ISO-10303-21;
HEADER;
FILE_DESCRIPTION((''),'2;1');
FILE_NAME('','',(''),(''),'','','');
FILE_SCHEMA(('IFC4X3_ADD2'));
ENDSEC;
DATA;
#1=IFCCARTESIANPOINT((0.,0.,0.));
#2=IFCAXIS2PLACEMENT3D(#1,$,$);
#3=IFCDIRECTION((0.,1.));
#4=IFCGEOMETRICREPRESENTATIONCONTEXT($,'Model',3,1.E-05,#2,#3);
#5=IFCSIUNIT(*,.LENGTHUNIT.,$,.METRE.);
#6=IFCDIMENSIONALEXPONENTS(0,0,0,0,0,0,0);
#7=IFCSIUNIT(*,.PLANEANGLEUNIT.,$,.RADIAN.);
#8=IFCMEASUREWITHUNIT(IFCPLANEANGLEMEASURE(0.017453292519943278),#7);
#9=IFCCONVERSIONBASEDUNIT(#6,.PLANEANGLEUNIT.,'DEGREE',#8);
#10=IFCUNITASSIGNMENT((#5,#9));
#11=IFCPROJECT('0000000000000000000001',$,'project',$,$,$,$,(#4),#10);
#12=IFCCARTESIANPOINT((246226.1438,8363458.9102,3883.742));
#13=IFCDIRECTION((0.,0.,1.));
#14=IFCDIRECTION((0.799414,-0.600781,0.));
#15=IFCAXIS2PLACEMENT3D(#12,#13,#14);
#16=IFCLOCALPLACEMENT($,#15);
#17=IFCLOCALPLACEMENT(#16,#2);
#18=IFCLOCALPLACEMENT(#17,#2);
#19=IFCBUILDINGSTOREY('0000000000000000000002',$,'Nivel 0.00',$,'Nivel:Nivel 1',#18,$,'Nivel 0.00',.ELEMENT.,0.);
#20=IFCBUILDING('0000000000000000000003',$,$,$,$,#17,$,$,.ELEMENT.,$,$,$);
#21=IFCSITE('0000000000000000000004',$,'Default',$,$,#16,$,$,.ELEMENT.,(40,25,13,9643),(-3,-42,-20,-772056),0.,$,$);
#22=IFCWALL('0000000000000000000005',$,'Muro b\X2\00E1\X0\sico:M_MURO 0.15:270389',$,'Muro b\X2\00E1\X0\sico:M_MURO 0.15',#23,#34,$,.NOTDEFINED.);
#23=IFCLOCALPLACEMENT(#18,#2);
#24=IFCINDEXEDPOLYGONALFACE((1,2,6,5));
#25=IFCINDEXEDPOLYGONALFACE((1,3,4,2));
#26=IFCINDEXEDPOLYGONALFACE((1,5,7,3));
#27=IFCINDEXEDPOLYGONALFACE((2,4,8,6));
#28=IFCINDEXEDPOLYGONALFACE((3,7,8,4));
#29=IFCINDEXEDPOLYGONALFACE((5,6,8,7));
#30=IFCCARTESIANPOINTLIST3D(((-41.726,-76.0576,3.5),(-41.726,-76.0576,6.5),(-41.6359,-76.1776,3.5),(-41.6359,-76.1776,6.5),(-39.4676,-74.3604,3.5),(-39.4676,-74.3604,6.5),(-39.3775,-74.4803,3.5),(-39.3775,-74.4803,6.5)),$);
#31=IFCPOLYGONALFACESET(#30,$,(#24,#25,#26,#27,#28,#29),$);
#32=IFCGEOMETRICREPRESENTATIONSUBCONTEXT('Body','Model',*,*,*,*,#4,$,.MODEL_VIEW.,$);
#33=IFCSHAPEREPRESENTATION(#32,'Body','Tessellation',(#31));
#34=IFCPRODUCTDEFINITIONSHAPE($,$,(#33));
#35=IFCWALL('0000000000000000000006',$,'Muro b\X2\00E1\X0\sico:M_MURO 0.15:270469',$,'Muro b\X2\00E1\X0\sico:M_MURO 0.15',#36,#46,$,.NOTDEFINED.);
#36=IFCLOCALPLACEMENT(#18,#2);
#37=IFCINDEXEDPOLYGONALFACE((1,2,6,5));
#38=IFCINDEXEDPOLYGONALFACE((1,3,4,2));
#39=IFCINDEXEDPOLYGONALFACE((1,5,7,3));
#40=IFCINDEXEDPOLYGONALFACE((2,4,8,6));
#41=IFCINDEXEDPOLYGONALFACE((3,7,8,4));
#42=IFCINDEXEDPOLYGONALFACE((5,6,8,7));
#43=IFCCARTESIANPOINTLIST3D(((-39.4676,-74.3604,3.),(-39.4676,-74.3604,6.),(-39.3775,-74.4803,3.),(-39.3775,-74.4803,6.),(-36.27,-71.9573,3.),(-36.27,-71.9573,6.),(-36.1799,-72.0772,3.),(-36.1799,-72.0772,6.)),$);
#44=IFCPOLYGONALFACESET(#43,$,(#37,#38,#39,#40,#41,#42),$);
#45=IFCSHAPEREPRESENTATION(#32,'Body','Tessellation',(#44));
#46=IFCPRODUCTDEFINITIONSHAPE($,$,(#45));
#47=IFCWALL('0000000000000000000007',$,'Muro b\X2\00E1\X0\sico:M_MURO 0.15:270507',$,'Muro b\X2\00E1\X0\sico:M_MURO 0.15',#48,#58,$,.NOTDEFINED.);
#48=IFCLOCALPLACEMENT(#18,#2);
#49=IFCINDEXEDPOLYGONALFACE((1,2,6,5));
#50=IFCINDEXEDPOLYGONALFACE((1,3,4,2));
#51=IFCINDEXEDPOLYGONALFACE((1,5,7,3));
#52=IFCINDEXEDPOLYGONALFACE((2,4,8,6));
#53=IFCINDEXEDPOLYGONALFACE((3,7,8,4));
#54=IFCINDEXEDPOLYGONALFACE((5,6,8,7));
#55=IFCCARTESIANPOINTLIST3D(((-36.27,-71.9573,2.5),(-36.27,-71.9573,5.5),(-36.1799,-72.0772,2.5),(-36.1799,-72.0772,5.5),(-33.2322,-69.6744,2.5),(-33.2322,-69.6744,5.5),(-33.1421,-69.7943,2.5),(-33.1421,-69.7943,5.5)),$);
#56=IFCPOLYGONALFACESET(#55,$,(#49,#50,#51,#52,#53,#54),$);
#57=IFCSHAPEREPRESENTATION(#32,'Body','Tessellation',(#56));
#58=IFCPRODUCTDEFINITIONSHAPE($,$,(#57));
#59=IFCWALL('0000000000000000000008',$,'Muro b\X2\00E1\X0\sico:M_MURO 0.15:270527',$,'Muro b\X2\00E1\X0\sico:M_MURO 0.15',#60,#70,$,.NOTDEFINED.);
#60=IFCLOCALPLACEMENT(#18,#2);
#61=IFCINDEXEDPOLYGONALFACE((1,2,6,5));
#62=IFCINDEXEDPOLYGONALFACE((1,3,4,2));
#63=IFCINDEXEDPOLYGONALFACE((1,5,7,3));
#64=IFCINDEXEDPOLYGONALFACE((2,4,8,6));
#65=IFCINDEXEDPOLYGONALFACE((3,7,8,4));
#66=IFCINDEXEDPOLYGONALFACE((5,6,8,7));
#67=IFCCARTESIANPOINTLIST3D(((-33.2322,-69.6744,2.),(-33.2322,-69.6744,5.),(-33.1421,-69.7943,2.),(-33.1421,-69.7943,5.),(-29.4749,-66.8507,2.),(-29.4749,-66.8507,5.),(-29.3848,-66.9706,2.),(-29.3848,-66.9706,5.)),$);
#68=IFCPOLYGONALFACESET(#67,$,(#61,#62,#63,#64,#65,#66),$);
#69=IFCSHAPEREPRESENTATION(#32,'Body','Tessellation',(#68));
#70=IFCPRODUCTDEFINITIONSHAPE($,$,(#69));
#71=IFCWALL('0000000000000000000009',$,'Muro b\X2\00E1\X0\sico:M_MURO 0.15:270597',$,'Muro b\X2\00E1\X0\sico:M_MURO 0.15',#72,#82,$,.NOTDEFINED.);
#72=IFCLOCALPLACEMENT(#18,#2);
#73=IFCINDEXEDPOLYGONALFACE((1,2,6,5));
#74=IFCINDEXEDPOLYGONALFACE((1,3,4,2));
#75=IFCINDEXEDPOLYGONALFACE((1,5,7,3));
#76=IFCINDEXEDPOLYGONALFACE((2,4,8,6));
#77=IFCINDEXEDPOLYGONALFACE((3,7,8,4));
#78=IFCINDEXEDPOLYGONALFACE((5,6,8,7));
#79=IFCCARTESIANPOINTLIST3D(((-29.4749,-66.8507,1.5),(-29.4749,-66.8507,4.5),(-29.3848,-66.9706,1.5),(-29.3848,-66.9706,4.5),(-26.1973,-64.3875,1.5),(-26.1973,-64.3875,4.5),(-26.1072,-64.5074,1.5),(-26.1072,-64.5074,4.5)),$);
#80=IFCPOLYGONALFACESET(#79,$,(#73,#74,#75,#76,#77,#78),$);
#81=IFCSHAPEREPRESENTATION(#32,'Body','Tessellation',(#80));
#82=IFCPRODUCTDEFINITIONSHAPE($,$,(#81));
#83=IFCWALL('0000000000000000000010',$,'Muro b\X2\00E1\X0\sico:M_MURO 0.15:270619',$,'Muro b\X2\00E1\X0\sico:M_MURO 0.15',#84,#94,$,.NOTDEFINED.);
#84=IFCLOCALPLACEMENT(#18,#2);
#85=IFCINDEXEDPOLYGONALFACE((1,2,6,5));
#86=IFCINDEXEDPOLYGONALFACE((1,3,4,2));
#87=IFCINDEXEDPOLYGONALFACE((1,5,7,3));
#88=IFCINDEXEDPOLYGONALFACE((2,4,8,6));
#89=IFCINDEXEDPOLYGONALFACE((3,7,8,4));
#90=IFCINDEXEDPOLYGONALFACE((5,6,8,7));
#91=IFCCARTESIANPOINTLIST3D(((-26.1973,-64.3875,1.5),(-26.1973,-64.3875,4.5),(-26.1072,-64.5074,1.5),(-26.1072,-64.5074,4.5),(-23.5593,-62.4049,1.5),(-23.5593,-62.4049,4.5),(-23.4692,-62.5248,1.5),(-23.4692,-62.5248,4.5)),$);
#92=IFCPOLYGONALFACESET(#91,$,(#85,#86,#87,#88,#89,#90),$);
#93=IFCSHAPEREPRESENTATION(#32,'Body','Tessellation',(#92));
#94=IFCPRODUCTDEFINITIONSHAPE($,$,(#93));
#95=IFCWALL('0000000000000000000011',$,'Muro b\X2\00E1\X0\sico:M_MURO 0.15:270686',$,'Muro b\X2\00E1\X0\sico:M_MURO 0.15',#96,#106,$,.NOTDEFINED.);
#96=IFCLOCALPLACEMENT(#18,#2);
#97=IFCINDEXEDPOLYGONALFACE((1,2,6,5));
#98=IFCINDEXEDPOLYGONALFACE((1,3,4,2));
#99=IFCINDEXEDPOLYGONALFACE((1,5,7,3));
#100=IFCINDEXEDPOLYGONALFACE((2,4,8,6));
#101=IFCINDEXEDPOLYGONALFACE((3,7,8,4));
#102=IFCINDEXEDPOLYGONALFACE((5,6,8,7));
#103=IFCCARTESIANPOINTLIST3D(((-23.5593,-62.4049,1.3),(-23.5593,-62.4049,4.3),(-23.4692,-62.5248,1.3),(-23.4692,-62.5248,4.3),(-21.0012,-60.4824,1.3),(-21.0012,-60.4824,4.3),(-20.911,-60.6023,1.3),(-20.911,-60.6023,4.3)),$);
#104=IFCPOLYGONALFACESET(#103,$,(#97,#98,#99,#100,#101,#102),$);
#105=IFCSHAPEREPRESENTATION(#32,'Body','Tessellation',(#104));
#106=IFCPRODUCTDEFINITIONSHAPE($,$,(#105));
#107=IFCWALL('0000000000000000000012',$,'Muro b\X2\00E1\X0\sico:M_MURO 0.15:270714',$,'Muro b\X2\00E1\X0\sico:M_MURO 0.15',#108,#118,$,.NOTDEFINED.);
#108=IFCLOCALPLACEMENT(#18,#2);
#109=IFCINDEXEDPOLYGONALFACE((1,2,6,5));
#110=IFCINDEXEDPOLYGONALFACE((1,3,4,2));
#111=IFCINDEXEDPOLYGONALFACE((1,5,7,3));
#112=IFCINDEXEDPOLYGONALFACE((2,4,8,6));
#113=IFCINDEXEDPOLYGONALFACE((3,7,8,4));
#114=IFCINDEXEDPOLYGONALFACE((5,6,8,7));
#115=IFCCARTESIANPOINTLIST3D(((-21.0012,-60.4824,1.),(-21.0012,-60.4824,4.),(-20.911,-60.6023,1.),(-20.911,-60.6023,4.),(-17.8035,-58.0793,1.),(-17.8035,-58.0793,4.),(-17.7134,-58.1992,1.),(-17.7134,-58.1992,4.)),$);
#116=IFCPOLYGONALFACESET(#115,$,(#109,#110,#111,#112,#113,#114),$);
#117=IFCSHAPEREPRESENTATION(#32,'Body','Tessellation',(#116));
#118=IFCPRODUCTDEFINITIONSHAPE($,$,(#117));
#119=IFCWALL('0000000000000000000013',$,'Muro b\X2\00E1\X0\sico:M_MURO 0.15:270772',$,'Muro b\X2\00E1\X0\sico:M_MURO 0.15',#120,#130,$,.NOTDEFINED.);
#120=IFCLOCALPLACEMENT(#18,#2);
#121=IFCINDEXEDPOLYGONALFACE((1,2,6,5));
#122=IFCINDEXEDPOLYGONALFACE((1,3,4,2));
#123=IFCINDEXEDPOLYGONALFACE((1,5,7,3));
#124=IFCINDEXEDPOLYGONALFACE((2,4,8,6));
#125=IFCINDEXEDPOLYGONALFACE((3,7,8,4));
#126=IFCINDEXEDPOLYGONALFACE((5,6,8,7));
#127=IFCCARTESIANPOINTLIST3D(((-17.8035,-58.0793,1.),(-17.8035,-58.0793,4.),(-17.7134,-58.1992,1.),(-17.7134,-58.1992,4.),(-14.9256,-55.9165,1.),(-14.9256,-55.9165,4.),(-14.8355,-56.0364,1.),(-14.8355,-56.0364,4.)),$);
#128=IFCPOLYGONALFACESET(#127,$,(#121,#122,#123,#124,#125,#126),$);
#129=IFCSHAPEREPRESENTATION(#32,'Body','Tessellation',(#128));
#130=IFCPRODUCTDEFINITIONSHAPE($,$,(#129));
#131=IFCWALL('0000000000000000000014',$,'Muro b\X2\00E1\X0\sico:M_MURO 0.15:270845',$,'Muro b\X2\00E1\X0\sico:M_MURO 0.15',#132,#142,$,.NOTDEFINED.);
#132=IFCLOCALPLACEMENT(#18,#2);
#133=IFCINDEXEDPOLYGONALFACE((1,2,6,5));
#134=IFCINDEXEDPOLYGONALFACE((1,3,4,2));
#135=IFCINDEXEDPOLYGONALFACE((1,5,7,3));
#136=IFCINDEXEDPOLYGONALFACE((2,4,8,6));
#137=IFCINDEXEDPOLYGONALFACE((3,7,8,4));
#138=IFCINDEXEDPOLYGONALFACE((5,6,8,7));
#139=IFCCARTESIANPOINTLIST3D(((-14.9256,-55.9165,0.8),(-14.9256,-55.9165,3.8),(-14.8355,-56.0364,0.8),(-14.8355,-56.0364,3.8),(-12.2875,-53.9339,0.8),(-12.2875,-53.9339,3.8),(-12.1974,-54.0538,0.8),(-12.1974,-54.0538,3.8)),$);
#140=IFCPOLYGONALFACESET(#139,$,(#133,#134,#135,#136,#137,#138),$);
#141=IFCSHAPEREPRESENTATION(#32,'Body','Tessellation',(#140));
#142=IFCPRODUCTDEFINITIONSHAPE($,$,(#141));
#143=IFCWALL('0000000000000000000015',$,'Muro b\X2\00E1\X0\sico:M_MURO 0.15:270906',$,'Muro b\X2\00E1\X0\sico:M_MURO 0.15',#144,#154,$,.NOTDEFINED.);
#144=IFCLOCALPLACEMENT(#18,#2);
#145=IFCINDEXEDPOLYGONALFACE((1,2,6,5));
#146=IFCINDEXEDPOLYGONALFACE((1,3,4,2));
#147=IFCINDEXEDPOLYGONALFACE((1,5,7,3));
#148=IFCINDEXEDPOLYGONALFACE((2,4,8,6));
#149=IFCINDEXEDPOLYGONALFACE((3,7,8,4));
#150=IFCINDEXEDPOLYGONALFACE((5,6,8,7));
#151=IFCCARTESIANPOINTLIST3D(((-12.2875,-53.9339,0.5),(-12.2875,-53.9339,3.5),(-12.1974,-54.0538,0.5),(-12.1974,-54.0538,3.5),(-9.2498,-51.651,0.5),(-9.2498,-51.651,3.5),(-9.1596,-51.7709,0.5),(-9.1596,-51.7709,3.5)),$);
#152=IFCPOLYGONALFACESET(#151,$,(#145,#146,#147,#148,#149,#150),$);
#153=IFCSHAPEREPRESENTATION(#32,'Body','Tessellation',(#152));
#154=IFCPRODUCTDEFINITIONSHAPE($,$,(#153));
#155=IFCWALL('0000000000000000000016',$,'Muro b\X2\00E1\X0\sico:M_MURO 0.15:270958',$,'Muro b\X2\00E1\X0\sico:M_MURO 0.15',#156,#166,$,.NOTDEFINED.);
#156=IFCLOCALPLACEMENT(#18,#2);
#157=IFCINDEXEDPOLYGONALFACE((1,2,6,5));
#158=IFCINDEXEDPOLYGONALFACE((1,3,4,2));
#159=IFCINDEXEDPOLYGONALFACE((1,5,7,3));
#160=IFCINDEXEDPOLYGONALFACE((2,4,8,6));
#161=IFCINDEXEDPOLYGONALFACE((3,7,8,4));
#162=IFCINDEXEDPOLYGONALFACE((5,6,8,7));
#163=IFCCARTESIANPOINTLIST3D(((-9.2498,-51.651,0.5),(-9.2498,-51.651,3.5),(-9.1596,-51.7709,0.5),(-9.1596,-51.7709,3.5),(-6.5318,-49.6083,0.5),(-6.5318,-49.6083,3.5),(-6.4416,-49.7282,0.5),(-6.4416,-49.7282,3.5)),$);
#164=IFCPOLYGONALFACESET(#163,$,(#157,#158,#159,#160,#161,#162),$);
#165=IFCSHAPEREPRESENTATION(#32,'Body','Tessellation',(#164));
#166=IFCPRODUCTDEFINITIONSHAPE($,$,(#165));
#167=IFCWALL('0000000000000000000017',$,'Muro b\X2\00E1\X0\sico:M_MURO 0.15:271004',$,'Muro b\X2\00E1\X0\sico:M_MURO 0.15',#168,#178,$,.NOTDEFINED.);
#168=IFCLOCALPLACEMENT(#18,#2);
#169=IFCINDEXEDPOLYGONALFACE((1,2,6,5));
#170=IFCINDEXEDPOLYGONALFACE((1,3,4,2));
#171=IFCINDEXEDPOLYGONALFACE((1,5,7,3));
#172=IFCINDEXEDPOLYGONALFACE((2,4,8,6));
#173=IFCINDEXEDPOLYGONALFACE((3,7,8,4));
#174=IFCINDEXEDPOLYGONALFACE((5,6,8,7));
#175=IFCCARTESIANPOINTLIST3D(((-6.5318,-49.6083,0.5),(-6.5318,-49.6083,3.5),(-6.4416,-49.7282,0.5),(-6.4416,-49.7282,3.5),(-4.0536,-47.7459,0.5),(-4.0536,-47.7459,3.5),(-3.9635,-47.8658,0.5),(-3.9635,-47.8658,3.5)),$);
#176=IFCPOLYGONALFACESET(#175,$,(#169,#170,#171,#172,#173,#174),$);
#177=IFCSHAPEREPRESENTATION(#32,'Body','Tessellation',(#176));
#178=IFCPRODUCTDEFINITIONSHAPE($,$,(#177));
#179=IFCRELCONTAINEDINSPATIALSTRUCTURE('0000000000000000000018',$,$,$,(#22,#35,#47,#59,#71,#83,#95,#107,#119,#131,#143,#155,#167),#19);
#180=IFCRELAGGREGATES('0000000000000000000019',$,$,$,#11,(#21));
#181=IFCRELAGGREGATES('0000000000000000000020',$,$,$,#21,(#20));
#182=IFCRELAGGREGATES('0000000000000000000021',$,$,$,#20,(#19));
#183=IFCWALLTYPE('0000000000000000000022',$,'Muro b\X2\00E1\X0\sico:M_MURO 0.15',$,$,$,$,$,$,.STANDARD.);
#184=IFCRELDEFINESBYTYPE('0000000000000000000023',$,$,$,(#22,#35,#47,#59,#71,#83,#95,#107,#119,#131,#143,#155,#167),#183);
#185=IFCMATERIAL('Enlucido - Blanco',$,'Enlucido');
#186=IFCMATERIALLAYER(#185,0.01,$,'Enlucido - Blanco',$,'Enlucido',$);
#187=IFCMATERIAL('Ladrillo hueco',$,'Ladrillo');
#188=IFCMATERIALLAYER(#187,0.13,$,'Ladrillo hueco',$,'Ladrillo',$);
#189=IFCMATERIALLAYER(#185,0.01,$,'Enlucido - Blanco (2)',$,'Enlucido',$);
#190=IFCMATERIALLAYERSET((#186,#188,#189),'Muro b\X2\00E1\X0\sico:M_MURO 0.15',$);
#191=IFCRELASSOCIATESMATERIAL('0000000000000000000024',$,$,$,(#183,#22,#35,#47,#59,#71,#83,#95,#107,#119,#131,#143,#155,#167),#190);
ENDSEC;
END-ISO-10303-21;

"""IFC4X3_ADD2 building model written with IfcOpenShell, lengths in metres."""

from ifc_helpers import new_model, entity, si_unit, converted_unit, direction, frame, frame_2d, origin, place, context, subcontext, project, spatial, rectangle, extrude, material, layer, layer_set, type_object, element, save


model = new_model("IFC4X3_ADD2")

# Units and contexts
model_context = context("Model", 3, precision=1e-05, world=origin(), true_north=direction((0.0, 1.0)))
body_context = subcontext(model_context, "Body", "Model", "MODEL_VIEW")
ifc_project = project(units=[si_unit("LENGTHUNIT", "METRE"), converted_unit("PLANEANGLEUNIT", "DEGREE", entity("IfcPlaneAngleMeasure", 0.017453292519943278), si_unit("PLANEANGLEUNIT", "RADIAN"), dimensions=[0, 0, 0, 0, 0, 0, 0])], contexts=[model_context])

# Site, building, storey
site_placement = place(None, frame((246226.1438, 8363458.9102, 3883.742), z_axis=(0.0, 0.0, 1.0), x_axis=(0.799414, -0.600781, 0.0)))
site = spatial("IfcSite", under=ifc_project, at=site_placement, Name="Default", CompositionType="ELEMENT", RefLatitude=(40, 25, 13, 9643), RefLongitude=(-3, -42, -20, -772056), RefElevation=0.0)
building_placement = place(site_placement, origin())
building = spatial("IfcBuilding", under=site, at=building_placement, CompositionType="ELEMENT")
storey_placement = place(building_placement, origin())
storey = spatial("IfcBuildingStorey", under=building, at=storey_placement, Name="Nivel 0.00", ObjectType="Nivel:Nivel 1", LongName="Nivel 0.00", CompositionType="ELEMENT", Elevation=0.0)

# Walls
ifc_material_1 = material(Name="Enlucido - Blanco", Category="Enlucido")
ifc_layer_1 = layer(ifc_material_1, 0.01, Name="Enlucido - Blanco", Category="Enlucido")
ifc_material_2 = material(Name="Ladrillo hueco", Category="Ladrillo")
ifc_layer_2 = layer(ifc_material_2, 0.13, Name="Ladrillo hueco", Category="Ladrillo")
ifc_layer_3 = layer(ifc_material_1, 0.01, Name="Enlucido - Blanco (2)", Category="Enlucido")
ifc_layer_set_1 = layer_set([ifc_layer_1, ifc_layer_2, ifc_layer_3], Name="Muro básico:M_MURO 0.15")
wall_type = type_object("IfcWallType", Name="Muro básico:M_MURO 0.15", PredefinedType="STANDARD", material=ifc_layer_set_1)
wall_1_placement = place(storey_placement, frame((-39.4226, -74.4204, 3.5), z_axis=(0.0, 0.0, 1.0), x_axis=(-0.799414, -0.60078, 0.0)))
element("IfcWall", 1, at=wall_1_placement, inside=storey, type_object=wall_type, material=ifc_layer_set_1, Name="Muro básico:M_MURO 0.15:270389", ObjectType="Muro básico:M_MURO 0.15", PredefinedType="NOTDEFINED", context=body_context, shape_type="SweptSolid", body=[
    extrude(rectangle(XDim=2.825, YDim=0.15, at=frame_2d((1.4125, 0.0), x_axis=(-1.0, 0.0))), origin(), (0.0, 0.0, 1.0), 3.0),
])
wall_2_placement = place(storey_placement, frame((-36.2249, -72.0173, 3.0), z_axis=(0.0, 0.0, 1.0), x_axis=(-0.799414, -0.60078, 0.0)))
element("IfcWall", 2, at=wall_2_placement, inside=storey, type_object=wall_type, material=ifc_layer_set_1, Name="Muro básico:M_MURO 0.15:270469", ObjectType="Muro básico:M_MURO 0.15", PredefinedType="NOTDEFINED", context=body_context, shape_type="SweptSolid", body=[
    extrude(rectangle(XDim=4.0, YDim=0.15, at=frame_2d((2.0, 0.0), x_axis=(-1.0, 0.0))), origin(), (0.0, 0.0, 1.0), 3.0),
])
wall_3_placement = place(storey_placement, frame((-33.1871, -69.7343, 2.5), z_axis=(0.0, 0.0, 1.0), x_axis=(-0.799414, -0.60078, 0.0)))
element("IfcWall", 3, at=wall_3_placement, inside=storey, type_object=wall_type, material=ifc_layer_set_1, Name="Muro básico:M_MURO 0.15:270507", ObjectType="Muro básico:M_MURO 0.15", PredefinedType="NOTDEFINED", context=body_context, shape_type="SweptSolid", body=[
    extrude(rectangle(XDim=3.8, YDim=0.15, at=frame_2d((1.9, 0.0), x_axis=(-1.0, 0.0))), origin(), (0.0, 0.0, 1.0), 3.0),
])
wall_4_placement = place(storey_placement, frame((-29.4299, -66.9106, 2.0), z_axis=(0.0, 0.0, 1.0), x_axis=(-0.799414, -0.60078, 0.0)))
element("IfcWall", 4, at=wall_4_placement, inside=storey, type_object=wall_type, material=ifc_layer_set_1, Name="Muro básico:M_MURO 0.15:270527", ObjectType="Muro básico:M_MURO 0.15", PredefinedType="NOTDEFINED", context=body_context, shape_type="SweptSolid", body=[
    extrude(rectangle(XDim=4.7, YDim=0.15, at=frame_2d((2.35, 0.0), x_axis=(-1.0, 0.0))), origin(), (0.0, 0.0, 1.0), 3.0),
])
wall_5_placement = place(storey_placement, frame((-26.1523, -64.4474, 1.5), z_axis=(0.0, 0.0, 1.0), x_axis=(-0.799414, -0.60078, 0.0)))
element("IfcWall", 5, at=wall_5_placement, inside=storey, type_object=wall_type, material=ifc_layer_set_1, Name="Muro básico:M_MURO 0.15:270597", ObjectType="Muro básico:M_MURO 0.15", PredefinedType="NOTDEFINED", context=body_context, shape_type="SweptSolid", body=[
    extrude(rectangle(XDim=4.1, YDim=0.15, at=frame_2d((2.05, 0.0), x_axis=(-1.0, 0.0))), origin(), (0.0, 0.0, 1.0), 3.0),
])
wall_6_placement = place(storey_placement, frame((-23.5142, -62.4649, 1.5), z_axis=(0.0, 0.0, 1.0), x_axis=(-0.799414, -0.60078, 0.0)))
element("IfcWall", 6, at=wall_6_placement, inside=storey, type_object=wall_type, material=ifc_layer_set_1, Name="Muro básico:M_MURO 0.15:270619", ObjectType="Muro básico:M_MURO 0.15", PredefinedType="NOTDEFINED", context=body_context, shape_type="SweptSolid", body=[
    extrude(rectangle(XDim=3.3, YDim=0.15, at=frame_2d((1.65, 0.0), x_axis=(-1.0, 0.0))), origin(), (0.0, 0.0, 1.0), 3.0),
])
wall_7_placement = place(storey_placement, frame((-20.9561, -60.5424, 1.3), z_axis=(0.0, 0.0, 1.0), x_axis=(-0.799414, -0.60078, 0.0)))
element("IfcWall", 7, at=wall_7_placement, inside=storey, type_object=wall_type, material=ifc_layer_set_1, Name="Muro básico:M_MURO 0.15:270686", ObjectType="Muro básico:M_MURO 0.15", PredefinedType="NOTDEFINED", context=body_context, shape_type="SweptSolid", body=[
    extrude(rectangle(XDim=3.2, YDim=0.15, at=frame_2d((1.6, 0.0), x_axis=(-1.0, 0.0))), origin(), (0.0, 0.0, 1.0), 3.0),
])
wall_8_placement = place(storey_placement, frame((-17.7584, -58.1393, 1.0), z_axis=(0.0, 0.0, 1.0), x_axis=(-0.799414, -0.60078, 0.0)))
element("IfcWall", 8, at=wall_8_placement, inside=storey, type_object=wall_type, material=ifc_layer_set_1, Name="Muro básico:M_MURO 0.15:270714", ObjectType="Muro básico:M_MURO 0.15", PredefinedType="NOTDEFINED", context=body_context, shape_type="SweptSolid", body=[
    extrude(rectangle(XDim=4.0, YDim=0.15, at=frame_2d((2.0, 0.0), x_axis=(-1.0, 0.0))), origin(), (0.0, 0.0, 1.0), 3.0),
])
wall_9_placement = place(storey_placement, frame((-14.8805, -55.9764, 1.0), z_axis=(0.0, 0.0, 1.0), x_axis=(-0.799414, -0.60078, 0.0)))
element("IfcWall", 9, at=wall_9_placement, inside=storey, type_object=wall_type, material=ifc_layer_set_1, Name="Muro básico:M_MURO 0.15:270772", ObjectType="Muro básico:M_MURO 0.15", PredefinedType="NOTDEFINED", context=body_context, shape_type="SweptSolid", body=[
    extrude(rectangle(XDim=3.6, YDim=0.15, at=frame_2d((1.8, 0.0), x_axis=(-1.0, 0.0))), origin(), (0.0, 0.0, 1.0), 3.0),
])
wall_10_placement = place(storey_placement, frame((-12.2425, -53.9939, 0.8), z_axis=(0.0, 0.0, 1.0), x_axis=(-0.799414, -0.60078, 0.0)))
element("IfcWall", 10, at=wall_10_placement, inside=storey, type_object=wall_type, material=ifc_layer_set_1, Name="Muro básico:M_MURO 0.15:270845", ObjectType="Muro básico:M_MURO 0.15", PredefinedType="NOTDEFINED", context=body_context, shape_type="SweptSolid", body=[
    extrude(rectangle(XDim=3.3, YDim=0.15, at=frame_2d((1.65, 0.0), x_axis=(-1.0, 0.0))), origin(), (0.0, 0.0, 1.0), 3.0),
])
wall_11_placement = place(storey_placement, frame((-9.2047, -51.7109, 0.5), z_axis=(0.0, 0.0, 1.0), x_axis=(-0.799414, -0.60078, 0.0)))
element("IfcWall", 11, at=wall_11_placement, inside=storey, type_object=wall_type, material=ifc_layer_set_1, Name="Muro básico:M_MURO 0.15:270906", ObjectType="Muro básico:M_MURO 0.15", PredefinedType="NOTDEFINED", context=body_context, shape_type="SweptSolid", body=[
    extrude(rectangle(XDim=3.8, YDim=0.15, at=frame_2d((1.9, 0.0), x_axis=(-1.0, 0.0))), origin(), (0.0, 0.0, 1.0), 3.0),
])
wall_12_placement = place(storey_placement, frame((-6.4867, -49.6683, 0.5), z_axis=(0.0, 0.0, 1.0), x_axis=(-0.799414, -0.60078, 0.0)))
element("IfcWall", 12, at=wall_12_placement, inside=storey, type_object=wall_type, material=ifc_layer_set_1, Name="Muro básico:M_MURO 0.15:270958", ObjectType="Muro básico:M_MURO 0.15", PredefinedType="NOTDEFINED", context=body_context, shape_type="SweptSolid", body=[
    extrude(rectangle(XDim=3.4, YDim=0.15, at=frame_2d((1.7, 0.0), x_axis=(-1.0, 0.0))), origin(), (0.0, 0.0, 1.0), 3.0),
])
wall_13_placement = place(storey_placement, frame((-4.0085, -47.8058, 0.5), z_axis=(0.0, 0.0, 1.0), x_axis=(-0.799414, -0.60078, 0.0)))
element("IfcWall", 13, at=wall_13_placement, inside=storey, type_object=wall_type, material=ifc_layer_set_1, Name="Muro básico:M_MURO 0.15:271004", ObjectType="Muro básico:M_MURO 0.15", PredefinedType="NOTDEFINED", context=body_context, shape_type="SweptSolid", body=[
    extrude(rectangle(XDim=3.1, YDim=0.15, at=frame_2d((1.55, 0.0), x_axis=(-1.0, 0.0))), origin(), (0.0, 0.0, 1.0), 3.0),
])

save(model, "model.ifc")
